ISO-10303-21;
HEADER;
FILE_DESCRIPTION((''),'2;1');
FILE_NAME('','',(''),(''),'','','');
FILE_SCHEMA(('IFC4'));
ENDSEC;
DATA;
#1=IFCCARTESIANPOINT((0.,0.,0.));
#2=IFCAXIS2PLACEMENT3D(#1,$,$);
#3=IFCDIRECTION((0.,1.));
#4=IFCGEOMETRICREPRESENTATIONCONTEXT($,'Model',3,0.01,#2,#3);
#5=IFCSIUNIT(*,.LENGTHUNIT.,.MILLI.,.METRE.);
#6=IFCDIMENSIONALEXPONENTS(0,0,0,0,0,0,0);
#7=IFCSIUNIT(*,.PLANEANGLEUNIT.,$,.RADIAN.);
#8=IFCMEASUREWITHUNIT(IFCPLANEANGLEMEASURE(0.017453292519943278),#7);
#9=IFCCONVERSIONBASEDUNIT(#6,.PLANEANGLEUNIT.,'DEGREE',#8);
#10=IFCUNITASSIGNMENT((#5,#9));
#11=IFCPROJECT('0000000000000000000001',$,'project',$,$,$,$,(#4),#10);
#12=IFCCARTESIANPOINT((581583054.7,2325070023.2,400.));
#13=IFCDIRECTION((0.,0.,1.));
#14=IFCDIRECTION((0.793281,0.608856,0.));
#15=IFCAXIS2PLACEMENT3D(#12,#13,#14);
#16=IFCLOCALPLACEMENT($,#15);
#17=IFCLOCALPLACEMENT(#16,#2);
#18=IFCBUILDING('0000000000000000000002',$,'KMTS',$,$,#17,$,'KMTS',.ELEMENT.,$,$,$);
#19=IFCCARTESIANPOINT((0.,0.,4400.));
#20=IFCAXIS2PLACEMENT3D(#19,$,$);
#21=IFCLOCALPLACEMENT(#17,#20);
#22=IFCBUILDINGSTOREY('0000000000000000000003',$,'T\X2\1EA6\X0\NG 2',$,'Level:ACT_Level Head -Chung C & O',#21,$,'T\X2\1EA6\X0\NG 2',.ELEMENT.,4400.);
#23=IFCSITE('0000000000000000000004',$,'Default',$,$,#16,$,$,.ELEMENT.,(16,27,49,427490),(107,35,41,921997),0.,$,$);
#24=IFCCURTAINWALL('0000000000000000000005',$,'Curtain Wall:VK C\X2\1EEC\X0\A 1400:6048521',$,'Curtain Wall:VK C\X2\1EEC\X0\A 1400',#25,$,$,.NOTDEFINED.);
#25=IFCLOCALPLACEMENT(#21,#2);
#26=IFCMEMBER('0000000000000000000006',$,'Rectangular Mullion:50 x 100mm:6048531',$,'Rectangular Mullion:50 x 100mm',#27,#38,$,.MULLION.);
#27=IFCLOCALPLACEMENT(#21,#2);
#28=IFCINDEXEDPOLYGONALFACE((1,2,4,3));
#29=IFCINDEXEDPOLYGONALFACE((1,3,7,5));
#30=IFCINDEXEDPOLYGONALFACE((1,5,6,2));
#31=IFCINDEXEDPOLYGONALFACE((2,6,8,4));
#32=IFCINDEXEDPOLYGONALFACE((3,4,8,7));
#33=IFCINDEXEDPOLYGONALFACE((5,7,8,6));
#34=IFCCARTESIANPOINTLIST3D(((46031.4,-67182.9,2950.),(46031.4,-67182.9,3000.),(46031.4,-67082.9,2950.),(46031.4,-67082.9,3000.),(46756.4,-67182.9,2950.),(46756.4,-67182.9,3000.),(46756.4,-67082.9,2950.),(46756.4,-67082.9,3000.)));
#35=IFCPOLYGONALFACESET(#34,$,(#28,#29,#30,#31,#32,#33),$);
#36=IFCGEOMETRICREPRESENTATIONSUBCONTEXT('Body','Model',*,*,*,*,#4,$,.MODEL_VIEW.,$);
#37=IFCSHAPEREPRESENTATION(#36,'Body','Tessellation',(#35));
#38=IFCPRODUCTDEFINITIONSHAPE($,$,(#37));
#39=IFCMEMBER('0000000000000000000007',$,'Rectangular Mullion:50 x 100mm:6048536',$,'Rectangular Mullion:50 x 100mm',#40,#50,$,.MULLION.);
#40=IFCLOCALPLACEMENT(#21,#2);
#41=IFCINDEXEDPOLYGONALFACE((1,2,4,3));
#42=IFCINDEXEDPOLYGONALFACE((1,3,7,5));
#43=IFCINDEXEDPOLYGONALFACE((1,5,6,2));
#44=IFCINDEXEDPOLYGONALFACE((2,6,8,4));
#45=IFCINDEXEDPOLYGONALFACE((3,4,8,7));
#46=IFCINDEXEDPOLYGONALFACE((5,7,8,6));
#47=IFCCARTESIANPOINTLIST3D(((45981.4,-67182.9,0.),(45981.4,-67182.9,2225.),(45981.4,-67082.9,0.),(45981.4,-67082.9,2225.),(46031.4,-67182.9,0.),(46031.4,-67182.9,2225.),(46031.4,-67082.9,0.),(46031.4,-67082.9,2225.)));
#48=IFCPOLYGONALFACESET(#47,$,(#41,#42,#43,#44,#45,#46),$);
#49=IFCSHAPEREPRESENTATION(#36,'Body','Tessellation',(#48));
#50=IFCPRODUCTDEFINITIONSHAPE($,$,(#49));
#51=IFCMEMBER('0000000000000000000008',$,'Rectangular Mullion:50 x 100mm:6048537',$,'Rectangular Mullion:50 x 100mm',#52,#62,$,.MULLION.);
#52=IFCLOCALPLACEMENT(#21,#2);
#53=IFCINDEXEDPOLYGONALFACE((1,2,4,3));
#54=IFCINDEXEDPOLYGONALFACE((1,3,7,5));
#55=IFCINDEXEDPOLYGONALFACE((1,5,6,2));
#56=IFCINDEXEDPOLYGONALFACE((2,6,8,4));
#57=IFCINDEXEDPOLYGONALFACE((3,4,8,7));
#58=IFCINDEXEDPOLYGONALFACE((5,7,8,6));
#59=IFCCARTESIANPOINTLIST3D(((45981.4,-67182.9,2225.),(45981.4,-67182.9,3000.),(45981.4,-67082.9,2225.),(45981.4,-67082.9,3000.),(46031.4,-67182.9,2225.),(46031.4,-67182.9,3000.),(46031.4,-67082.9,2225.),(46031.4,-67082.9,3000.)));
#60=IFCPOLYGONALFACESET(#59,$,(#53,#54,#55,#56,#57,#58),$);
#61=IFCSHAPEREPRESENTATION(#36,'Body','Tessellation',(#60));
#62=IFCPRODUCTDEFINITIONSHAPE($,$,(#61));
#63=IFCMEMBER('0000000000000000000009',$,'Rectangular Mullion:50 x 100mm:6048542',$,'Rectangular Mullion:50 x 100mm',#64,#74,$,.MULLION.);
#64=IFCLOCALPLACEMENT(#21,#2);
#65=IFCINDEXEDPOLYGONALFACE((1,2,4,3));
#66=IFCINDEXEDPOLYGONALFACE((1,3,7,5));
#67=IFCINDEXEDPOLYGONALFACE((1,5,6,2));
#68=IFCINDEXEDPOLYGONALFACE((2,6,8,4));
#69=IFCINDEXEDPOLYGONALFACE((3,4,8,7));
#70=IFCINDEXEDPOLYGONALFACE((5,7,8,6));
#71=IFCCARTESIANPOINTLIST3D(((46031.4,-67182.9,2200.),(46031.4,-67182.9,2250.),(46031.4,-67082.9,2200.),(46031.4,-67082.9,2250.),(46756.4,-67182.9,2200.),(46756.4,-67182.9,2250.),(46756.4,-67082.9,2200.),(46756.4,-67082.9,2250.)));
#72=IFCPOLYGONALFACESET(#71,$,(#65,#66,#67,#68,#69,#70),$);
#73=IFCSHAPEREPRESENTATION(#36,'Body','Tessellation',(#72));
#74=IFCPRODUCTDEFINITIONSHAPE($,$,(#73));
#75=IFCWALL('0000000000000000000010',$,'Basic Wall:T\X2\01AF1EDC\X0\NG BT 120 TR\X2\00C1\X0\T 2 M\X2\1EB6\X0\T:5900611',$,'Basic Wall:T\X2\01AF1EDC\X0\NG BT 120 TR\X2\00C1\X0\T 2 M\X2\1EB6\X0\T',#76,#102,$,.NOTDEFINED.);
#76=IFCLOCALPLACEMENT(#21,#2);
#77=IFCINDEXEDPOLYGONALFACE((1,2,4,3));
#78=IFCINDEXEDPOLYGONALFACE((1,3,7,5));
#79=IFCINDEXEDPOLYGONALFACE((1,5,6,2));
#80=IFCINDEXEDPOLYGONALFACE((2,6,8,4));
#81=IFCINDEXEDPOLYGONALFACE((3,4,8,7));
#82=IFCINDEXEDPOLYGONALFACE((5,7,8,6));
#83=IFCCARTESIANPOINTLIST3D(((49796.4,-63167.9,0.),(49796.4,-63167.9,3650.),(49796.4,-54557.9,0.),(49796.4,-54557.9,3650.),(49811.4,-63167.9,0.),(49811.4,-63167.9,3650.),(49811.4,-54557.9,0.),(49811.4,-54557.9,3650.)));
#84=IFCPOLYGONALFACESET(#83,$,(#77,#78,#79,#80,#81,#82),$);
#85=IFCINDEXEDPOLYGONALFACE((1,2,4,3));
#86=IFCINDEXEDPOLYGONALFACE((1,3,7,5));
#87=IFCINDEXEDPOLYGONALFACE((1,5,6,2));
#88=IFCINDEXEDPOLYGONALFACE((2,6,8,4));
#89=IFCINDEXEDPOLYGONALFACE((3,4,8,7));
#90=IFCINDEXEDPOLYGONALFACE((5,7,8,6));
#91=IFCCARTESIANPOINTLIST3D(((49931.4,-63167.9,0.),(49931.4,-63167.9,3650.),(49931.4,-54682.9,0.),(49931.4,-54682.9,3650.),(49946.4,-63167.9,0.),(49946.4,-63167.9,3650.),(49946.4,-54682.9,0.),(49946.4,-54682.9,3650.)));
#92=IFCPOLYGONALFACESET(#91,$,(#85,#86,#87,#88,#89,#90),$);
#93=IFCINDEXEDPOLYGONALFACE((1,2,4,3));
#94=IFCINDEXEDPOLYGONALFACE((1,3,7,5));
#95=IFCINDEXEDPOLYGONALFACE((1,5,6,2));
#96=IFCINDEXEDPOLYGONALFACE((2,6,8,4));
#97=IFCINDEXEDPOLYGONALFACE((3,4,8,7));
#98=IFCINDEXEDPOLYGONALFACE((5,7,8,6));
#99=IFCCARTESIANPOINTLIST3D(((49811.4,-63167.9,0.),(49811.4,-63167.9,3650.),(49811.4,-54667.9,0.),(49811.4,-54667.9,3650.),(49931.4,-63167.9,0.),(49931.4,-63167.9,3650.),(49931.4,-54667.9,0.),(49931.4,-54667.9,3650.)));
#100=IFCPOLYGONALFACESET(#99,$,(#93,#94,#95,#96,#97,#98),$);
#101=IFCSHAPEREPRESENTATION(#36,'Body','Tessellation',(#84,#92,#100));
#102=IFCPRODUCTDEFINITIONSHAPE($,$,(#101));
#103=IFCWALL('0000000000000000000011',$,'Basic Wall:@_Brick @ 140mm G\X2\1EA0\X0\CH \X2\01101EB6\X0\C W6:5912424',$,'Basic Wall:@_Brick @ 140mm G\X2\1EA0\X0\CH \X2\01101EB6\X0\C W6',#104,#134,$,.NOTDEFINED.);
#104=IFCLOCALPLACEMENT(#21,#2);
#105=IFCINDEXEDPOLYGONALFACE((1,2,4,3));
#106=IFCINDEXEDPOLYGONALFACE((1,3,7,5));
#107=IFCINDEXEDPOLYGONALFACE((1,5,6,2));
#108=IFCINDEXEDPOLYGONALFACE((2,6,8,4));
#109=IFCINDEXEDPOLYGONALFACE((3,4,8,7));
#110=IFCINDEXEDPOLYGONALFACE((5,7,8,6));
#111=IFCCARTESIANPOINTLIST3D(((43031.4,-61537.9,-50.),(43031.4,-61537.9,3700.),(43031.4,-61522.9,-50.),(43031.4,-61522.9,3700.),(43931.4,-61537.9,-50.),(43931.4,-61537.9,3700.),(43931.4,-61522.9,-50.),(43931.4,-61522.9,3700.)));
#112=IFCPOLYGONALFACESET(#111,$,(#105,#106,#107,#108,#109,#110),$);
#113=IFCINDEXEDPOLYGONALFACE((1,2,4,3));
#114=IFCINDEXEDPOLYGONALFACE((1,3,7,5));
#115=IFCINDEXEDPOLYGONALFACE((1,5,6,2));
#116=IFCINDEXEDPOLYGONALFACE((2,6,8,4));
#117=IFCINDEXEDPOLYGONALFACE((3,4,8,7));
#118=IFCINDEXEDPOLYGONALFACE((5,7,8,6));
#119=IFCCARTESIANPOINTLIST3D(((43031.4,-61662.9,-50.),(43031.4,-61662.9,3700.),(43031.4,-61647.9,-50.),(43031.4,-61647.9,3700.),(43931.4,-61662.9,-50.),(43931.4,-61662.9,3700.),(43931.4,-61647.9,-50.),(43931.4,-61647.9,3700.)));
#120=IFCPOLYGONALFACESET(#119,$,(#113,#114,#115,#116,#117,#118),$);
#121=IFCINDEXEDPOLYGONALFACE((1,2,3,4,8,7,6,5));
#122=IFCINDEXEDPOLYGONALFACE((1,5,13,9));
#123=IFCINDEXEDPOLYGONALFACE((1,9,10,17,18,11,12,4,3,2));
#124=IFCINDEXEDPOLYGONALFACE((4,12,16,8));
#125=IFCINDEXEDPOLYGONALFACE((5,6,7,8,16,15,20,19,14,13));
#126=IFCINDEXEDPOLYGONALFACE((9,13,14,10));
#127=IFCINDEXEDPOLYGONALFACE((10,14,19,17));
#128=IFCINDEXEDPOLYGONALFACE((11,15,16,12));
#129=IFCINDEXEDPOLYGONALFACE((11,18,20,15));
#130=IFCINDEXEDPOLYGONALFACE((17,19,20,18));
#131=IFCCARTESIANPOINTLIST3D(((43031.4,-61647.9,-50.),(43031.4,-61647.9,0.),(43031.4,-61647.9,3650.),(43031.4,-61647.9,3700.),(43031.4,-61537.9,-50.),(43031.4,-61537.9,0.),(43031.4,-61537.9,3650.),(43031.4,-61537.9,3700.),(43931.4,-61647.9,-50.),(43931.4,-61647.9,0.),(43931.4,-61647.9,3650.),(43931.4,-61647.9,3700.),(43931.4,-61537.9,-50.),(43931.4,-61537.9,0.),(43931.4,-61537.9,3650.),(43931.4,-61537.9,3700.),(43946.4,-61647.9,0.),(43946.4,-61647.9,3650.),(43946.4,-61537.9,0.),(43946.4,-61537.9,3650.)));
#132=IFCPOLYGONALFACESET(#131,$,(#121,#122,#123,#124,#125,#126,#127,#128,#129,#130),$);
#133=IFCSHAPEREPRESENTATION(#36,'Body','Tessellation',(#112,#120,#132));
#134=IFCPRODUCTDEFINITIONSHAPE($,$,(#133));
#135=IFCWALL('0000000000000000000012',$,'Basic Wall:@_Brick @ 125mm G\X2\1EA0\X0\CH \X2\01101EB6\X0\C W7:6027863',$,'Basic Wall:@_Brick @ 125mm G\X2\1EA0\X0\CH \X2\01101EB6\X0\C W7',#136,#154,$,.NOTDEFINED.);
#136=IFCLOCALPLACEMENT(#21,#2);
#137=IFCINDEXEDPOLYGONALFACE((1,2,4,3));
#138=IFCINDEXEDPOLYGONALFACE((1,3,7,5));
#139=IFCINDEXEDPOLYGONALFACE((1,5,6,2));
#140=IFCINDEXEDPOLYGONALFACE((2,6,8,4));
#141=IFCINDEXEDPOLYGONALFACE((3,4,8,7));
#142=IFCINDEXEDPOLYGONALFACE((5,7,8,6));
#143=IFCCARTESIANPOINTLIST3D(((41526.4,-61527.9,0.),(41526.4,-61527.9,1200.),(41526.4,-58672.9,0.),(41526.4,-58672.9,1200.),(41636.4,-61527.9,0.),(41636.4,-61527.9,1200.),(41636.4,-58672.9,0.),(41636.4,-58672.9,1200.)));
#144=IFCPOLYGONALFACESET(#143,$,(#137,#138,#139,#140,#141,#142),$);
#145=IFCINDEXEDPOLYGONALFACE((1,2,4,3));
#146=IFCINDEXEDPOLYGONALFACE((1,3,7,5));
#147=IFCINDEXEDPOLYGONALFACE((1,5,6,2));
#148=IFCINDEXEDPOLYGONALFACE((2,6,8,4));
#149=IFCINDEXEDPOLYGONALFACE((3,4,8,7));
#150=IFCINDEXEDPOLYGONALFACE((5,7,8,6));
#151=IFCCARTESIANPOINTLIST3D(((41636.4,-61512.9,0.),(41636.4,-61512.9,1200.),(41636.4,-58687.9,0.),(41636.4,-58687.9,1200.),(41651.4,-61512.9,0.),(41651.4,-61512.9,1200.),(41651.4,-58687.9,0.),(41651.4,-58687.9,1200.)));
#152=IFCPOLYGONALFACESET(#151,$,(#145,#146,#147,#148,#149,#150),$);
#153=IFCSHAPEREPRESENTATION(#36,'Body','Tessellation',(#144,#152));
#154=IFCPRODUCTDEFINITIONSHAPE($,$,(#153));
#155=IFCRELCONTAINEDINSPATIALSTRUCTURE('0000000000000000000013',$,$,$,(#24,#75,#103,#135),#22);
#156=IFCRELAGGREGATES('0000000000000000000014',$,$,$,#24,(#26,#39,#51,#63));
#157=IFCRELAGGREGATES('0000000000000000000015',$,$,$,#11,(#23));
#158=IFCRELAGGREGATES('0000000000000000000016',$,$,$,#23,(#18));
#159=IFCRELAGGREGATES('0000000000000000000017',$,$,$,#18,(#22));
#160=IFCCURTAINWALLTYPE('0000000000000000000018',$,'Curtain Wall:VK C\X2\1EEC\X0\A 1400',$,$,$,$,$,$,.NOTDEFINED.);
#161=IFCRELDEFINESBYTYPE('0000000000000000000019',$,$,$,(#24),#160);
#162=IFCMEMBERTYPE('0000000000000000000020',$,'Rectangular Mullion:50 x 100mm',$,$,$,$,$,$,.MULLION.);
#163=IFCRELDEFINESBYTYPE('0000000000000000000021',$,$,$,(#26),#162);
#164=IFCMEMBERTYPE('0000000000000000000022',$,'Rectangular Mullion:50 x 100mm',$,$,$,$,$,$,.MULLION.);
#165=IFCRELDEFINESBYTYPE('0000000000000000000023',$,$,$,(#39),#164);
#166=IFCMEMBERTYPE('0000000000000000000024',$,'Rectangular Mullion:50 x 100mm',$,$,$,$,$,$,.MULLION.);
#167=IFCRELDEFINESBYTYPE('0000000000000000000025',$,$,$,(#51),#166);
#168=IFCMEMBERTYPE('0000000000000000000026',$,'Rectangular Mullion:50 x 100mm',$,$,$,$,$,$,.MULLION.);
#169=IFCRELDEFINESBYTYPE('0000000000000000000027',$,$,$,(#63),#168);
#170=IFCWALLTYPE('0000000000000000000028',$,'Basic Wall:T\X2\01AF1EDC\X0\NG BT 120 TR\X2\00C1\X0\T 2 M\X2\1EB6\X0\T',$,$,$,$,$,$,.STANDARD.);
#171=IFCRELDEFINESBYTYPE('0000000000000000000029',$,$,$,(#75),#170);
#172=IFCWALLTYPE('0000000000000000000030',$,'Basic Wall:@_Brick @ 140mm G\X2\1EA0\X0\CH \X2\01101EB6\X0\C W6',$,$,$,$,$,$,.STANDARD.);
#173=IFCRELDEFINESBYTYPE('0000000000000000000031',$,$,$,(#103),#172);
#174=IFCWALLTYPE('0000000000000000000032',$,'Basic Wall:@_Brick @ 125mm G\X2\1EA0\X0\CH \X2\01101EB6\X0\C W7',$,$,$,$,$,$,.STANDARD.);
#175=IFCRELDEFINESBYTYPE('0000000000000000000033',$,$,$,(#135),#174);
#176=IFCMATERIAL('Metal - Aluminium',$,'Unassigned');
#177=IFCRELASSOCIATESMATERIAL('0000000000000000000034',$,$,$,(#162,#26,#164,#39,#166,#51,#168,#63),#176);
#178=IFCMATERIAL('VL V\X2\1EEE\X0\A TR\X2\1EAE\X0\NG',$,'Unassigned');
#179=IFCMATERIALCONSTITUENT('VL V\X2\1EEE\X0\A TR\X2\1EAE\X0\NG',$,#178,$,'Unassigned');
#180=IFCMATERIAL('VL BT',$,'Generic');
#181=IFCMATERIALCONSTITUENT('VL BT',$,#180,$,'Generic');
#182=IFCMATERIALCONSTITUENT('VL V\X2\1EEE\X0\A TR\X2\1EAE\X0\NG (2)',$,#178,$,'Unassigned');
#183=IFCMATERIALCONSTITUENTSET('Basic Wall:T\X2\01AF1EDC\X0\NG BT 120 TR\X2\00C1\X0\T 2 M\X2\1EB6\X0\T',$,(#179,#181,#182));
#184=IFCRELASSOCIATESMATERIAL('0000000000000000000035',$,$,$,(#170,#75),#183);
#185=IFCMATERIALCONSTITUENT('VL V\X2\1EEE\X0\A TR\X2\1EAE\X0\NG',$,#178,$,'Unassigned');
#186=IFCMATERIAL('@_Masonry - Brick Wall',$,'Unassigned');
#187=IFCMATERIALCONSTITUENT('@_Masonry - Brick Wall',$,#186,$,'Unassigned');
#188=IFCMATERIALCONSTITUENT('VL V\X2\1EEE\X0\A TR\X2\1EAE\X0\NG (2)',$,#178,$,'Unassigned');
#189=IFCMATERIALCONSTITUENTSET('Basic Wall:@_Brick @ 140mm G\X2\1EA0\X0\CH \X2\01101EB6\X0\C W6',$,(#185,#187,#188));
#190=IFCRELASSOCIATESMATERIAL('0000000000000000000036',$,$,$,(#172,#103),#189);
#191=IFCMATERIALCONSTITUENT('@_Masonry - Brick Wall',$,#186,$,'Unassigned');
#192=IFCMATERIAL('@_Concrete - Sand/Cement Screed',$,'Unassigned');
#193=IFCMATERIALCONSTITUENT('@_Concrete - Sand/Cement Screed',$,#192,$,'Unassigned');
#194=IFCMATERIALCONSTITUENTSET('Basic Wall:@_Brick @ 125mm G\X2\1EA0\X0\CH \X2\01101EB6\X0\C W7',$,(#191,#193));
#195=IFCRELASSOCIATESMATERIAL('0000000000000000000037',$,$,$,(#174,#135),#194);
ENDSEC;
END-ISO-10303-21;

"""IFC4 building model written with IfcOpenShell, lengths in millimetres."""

from ifc_helpers import new_model, entity, si_unit, converted_unit, direction, frame, origin, place, context, subcontext, project, spatial, indexed_curve, outline, extrude, source, transform, mapped, material, constituent, constituent_set, type_object, type_shapes, element, aggregate, save


model = new_model("IFC4")

# Units and contexts
model_context = context("Model", 3, precision=0.01, world=origin(), true_north=direction((0.0, 1.0)))
body_context = subcontext(model_context, "Body", "Model", "MODEL_VIEW")
ifc_project = project(units=[si_unit("LENGTHUNIT", "METRE", prefix="MILLI"), converted_unit("PLANEANGLEUNIT", "DEGREE", entity("IfcPlaneAngleMeasure", 0.017453292519943278), si_unit("PLANEANGLEUNIT", "RADIAN"), dimensions=[0, 0, 0, 0, 0, 0, 0])], contexts=[model_context])

# Site, building, storey
site_placement = place(None, frame((581583054.7, 2325070023.2, 400.0), z_axis=(0.0, 0.0, 1.0), x_axis=(0.793281, 0.608856, 0.0)))
site = spatial("IfcSite", under=ifc_project, at=site_placement, Name="Default", CompositionType="ELEMENT", RefLatitude=(16, 27, 49, 427490), RefLongitude=(107, 35, 41, 921997), RefElevation=0.0)
building_placement = place(site_placement, origin())
building = spatial("IfcBuilding", under=site, at=building_placement, Name="KMTS", LongName="KMTS", CompositionType="ELEMENT")
storey_placement = place(building_placement, frame((0.0, 0.0, 4400.0)))
storey = spatial("IfcBuildingStorey", under=building, at=storey_placement, Name="TẦNG 2", ObjectType="Level:ACT_Level Head -Chung C & O", LongName="TẦNG 2", CompositionType="ELEMENT", Elevation=4400.0)

# Curtain wall, members
curtain_wall_type = type_object("IfcCurtainWallType", Name="Curtain Wall:VK CỬA 1400", PredefinedType="NOTDEFINED")
curtain_wall_placement = place(storey_placement, frame((0.0, 0.0, -4400.0)))
curtain_wall = element("IfcCurtainWall", 1, at=curtain_wall_placement, inside=storey, type_object=curtain_wall_type, Name="Curtain Wall:VK CỬA 1400:6048521", ObjectType="Curtain Wall:VK CỬA 1400", PredefinedType="NOTDEFINED")
ifc_material_1 = material(Name="Metal - Aluminium", Category="Unassigned")
member_type_1 = type_object("IfcMemberType", Name="Rectangular Mullion:50 x 100mm", PredefinedType="MULLION", material=ifc_material_1)
shared_shape_1 = source(origin(), body_context, "Body", "SweptSolid", [
    extrude(outline(indexed_curve([(-25.0, -50.0), (25.0, -50.0), (25.0, 50.0), (-25.0, 50.0), (-25.0, -50.0)], self_intersect=False)), frame((-25.0, 0.0, -725.0), z_axis=(0.0, 0.0, 1.0), x_axis=(-1.0, 0.0, 0.0)), (0.0, 0.0, 1.0), 725.0),
])
type_shapes(member_type_1, [shared_shape_1])
member_1_placement = place(curtain_wall_placement, frame((46031.4, -67132.9, 7400.0), z_axis=(-1.0, 0.0, 0.0), x_axis=(0.0, 0.0, 1.0)))
member_1 = element("IfcMember", 2, at=member_1_placement, type_object=member_type_1, material=ifc_material_1, Name="Rectangular Mullion:50 x 100mm:6048531", ObjectType="Rectangular Mullion:50 x 100mm", PredefinedType="MULLION", context=body_context, shape_type="MappedRepresentation", body=[
    mapped(shared_shape_1, transform((0.0, 0.0, 0.0), scale=1.0)),
])
member_type_2 = type_object("IfcMemberType", Name="Rectangular Mullion:50 x 100mm", PredefinedType="MULLION", material=ifc_material_1)
shared_shape_2 = source(origin(), body_context, "Body", "SweptSolid", [
    extrude(outline(indexed_curve([(-25.0, -50.0), (25.0, -50.0), (25.0, 50.0), (-25.0, 50.0), (-25.0, -50.0)], self_intersect=False)), frame((-25.0, 0.0, -2225.0), z_axis=(0.0, 0.0, 1.0), x_axis=(-1.0, 0.0, 0.0)), (0.0, 0.0, 1.0), 2225.0),
])
type_shapes(member_type_2, [shared_shape_2])
member_2_placement = place(curtain_wall_placement, frame((45981.4, -67132.9, 4400.0), z_axis=(0.0, 0.0, -1.0), x_axis=(-1.0, 0.0, 0.0)))
member_2 = element("IfcMember", 3, at=member_2_placement, type_object=member_type_2, material=ifc_material_1, Name="Rectangular Mullion:50 x 100mm:6048536", ObjectType="Rectangular Mullion:50 x 100mm", PredefinedType="MULLION", context=body_context, shape_type="MappedRepresentation", body=[
    mapped(shared_shape_2, transform((0.0, 0.0, 0.0), scale=1.0)),
])
member_type_3 = type_object("IfcMemberType", Name="Rectangular Mullion:50 x 100mm", PredefinedType="MULLION", material=ifc_material_1)
shared_shape_3 = source(origin(), body_context, "Body", "SweptSolid", [
    extrude(outline(indexed_curve([(-25.0, -50.0), (25.0, -50.0), (25.0, 50.0), (-25.0, 50.0), (-25.0, -50.0)], self_intersect=False)), frame((-25.0, 0.0, -775.0), z_axis=(0.0, 0.0, 1.0), x_axis=(-1.0, 0.0, 0.0)), (0.0, 0.0, 1.0), 775.0),
])
type_shapes(member_type_3, [shared_shape_3])
member_3_placement = place(curtain_wall_placement, frame((45981.4, -67132.9, 6625.0), z_axis=(0.0, 0.0, -1.0), x_axis=(-1.0, 0.0, 0.0)))
member_3 = element("IfcMember", 4, at=member_3_placement, type_object=member_type_3, material=ifc_material_1, Name="Rectangular Mullion:50 x 100mm:6048537", ObjectType="Rectangular Mullion:50 x 100mm", PredefinedType="MULLION", context=body_context, shape_type="MappedRepresentation", body=[
    mapped(shared_shape_3, transform((0.0, 0.0, 0.0), scale=1.0)),
])
member_type_4 = type_object("IfcMemberType", Name="Rectangular Mullion:50 x 100mm", PredefinedType="MULLION", material=ifc_material_1)
shared_shape_4 = source(origin(), body_context, "Body", "SweptSolid", [
    extrude(outline(indexed_curve([(-25.0, -50.0), (25.0, -50.0), (25.0, 50.0), (-25.0, 50.0), (-25.0, -50.0)], self_intersect=False)), frame((0.0, 0.0, -725.0), z_axis=(0.0, 0.0, 1.0), x_axis=(-1.0, 0.0, 0.0)), (0.0, 0.0, 1.0), 725.0),
])
type_shapes(member_type_4, [shared_shape_4])
member_4_placement = place(curtain_wall_placement, frame((46031.4, -67132.9, 6625.0), z_axis=(-1.0, 0.0, 0.0), x_axis=(0.0, 0.0, 1.0)))
member_4 = element("IfcMember", 5, at=member_4_placement, type_object=member_type_4, material=ifc_material_1, Name="Rectangular Mullion:50 x 100mm:6048542", ObjectType="Rectangular Mullion:50 x 100mm", PredefinedType="MULLION", context=body_context, shape_type="MappedRepresentation", body=[
    mapped(shared_shape_4, transform((0.0, 0.0, 0.0), scale=1.0)),
])
aggregate(curtain_wall, [member_1, member_2, member_3, member_4])

# Shared definitions
ifc_material_2 = material(Name="VL VỮA TRẮNG", Category="Unassigned")
ifc_material_3 = material(Name="VL BT", Category="Generic")

# Shared definitions
ifc_constituent_1 = constituent(ifc_material_2, Name="VL VỮA TRẮNG", Category="Unassigned")
ifc_constituent_2 = constituent(ifc_material_3, Name="VL BT", Category="Generic")
ifc_constituent_3 = constituent(ifc_material_2, Name="VL VỮA TRẮNG (2)", Category="Unassigned")
ifc_constituent_set_1 = constituent_set(constituents=[ifc_constituent_1, ifc_constituent_2, ifc_constituent_3], Name="Basic Wall:TƯỜNG BT 120 TRÁT 2 MẶT")
wall_type_1 = type_object("IfcWallType", Name="Basic Wall:TƯỜNG BT 120 TRÁT 2 MẶT", PredefinedType="STANDARD", material=ifc_constituent_set_1)

# Wall
wall_1_placement = place(storey_placement, frame((49871.4, -54682.9, 0.0), z_axis=(0.0, 0.0, 1.0), x_axis=(0.0, -1.0, 0.0)))
element("IfcWall", 6, at=wall_1_placement, inside=storey, type_object=wall_type_1, material=ifc_constituent_set_1, Name="Basic Wall:TƯỜNG BT 120 TRÁT 2 MẶT:5900611", ObjectType="Basic Wall:TƯỜNG BT 120 TRÁT 2 MẶT", PredefinedType="NOTDEFINED", context=body_context, shape_type="SweptSolid", body=[
    extrude(outline(indexed_curve([(-7.5, -4305.0), (7.5, -4305.0), (7.5, 4305.0), (-7.5, 4305.0), (-7.5, -4305.0)], self_intersect=False)), frame((4180.0, -67.5, 0.0), z_axis=(0.0, 0.0, 1.0), x_axis=(0.0, 1.0, 0.0)), (0.0, 0.0, 1.0), 3650.0),
    extrude(outline(indexed_curve([(-7.5, -4242.5), (7.5, -4242.5), (7.5, 4242.5), (-7.5, 4242.5), (-7.5, -4242.5)], self_intersect=False)), frame((4242.5, 67.5, 0.0), z_axis=(0.0, 0.0, 1.0), x_axis=(0.0, -1.0, 0.0)), (0.0, 0.0, 1.0), 3650.0),
    extrude(outline(indexed_curve([(-4250.0, -60.0), (4250.0, -60.0), (4250.0, 60.0), (-4250.0, 60.0), (-4250.0, -60.0)], self_intersect=False)), frame((4235.0, 0.0, 0.0)), (0.0, 0.0, 1.0), 3650.0),
])

# Walls
ifc_constituent_4 = constituent(ifc_material_2, Name="VL VỮA TRẮNG", Category="Unassigned")
ifc_material_4 = material(Name="@_Masonry - Brick Wall", Category="Unassigned")
ifc_constituent_5 = constituent(ifc_material_4, Name="@_Masonry - Brick Wall", Category="Unassigned")
ifc_constituent_6 = constituent(ifc_material_2, Name="VL VỮA TRẮNG (2)", Category="Unassigned")
ifc_constituent_set_2 = constituent_set(constituents=[ifc_constituent_4, ifc_constituent_5, ifc_constituent_6], Name="Basic Wall:@_Brick @ 140mm GẠCH ĐẶC W6")
wall_type_2 = type_object("IfcWallType", Name="Basic Wall:@_Brick @ 140mm GẠCH ĐẶC W6", PredefinedType="STANDARD", material=ifc_constituent_set_2)
wall_2_placement = place(storey_placement, frame((43931.4, -61592.9, -50.0), z_axis=(0.0, 0.0, 1.0), x_axis=(-1.0, 0.0, 0.0)))
element("IfcWall", 7, at=wall_2_placement, inside=storey, type_object=wall_type_2, material=ifc_constituent_set_2, Name="Basic Wall:@_Brick @ 140mm GẠCH ĐẶC W6:5912424", ObjectType="Basic Wall:@_Brick @ 140mm GẠCH ĐẶC W6", PredefinedType="NOTDEFINED", context=body_context, shape_type="SweptSolid", body=[
    extrude(outline(indexed_curve([(-7.5, -450.0), (7.5, -450.0), (7.5, 450.0), (-7.5, 450.0), (-7.5, -450.0)], self_intersect=False)), frame((450.0, -62.5, 0.0), z_axis=(0.0, 0.0, 1.0), x_axis=(0.0, 1.0, 0.0)), (0.0, 0.0, 1.0), 3750.0),
    extrude(outline(indexed_curve([(-7.5, -450.0), (7.5, -450.0), (7.5, 450.0), (-7.5, 450.0), (-7.5, -450.0)], self_intersect=False)), frame((450.0, 62.5, 0.0), z_axis=(0.0, 0.0, 1.0), x_axis=(0.0, -1.0, 0.0)), (0.0, 0.0, 1.0), 3750.0),
    extrude(outline(indexed_curve([(-1875.0, -543.0), (-1825.0, -543.0), (1825.0, -543.0), (1875.0, -543.0), (1875.0, 357.0), (1825.0, 357.0), (1825.0, 372.0), (-1825.0, 372.0), (-1825.0, 357.0), (-1875.0, 357.0), (-1875.0, -543.0)], self_intersect=False)), frame((357.0, 55.0, 1875.0), z_axis=(0.0, -1.0, 0.0), x_axis=(0.0, 0.0, 1.0)), (0.0, 0.0, 1.0), 110.0),
])
ifc_constituent_7 = constituent(ifc_material_4, Name="@_Masonry - Brick Wall", Category="Unassigned")
ifc_material_5 = material(Name="@_Concrete - Sand/Cement Screed", Category="Unassigned")
ifc_constituent_8 = constituent(ifc_material_5, Name="@_Concrete - Sand/Cement Screed", Category="Unassigned")
ifc_constituent_set_3 = constituent_set(constituents=[ifc_constituent_7, ifc_constituent_8], Name="Basic Wall:@_Brick @ 125mm GẠCH ĐẶC W7")
wall_type_3 = type_object("IfcWallType", Name="Basic Wall:@_Brick @ 125mm GẠCH ĐẶC W7", PredefinedType="STANDARD", material=ifc_constituent_set_3)
wall_3_placement = place(storey_placement, frame((41588.9, -61512.9, 0.0), z_axis=(0.0, 0.0, 1.0), x_axis=(0.0, 1.0, 0.0)))
element("IfcWall", 8, at=wall_3_placement, inside=storey, type_object=wall_type_3, material=ifc_constituent_set_3, Name="Basic Wall:@_Brick @ 125mm GẠCH ĐẶC W7:6027863", ObjectType="Basic Wall:@_Brick @ 125mm GẠCH ĐẶC W7", PredefinedType="NOTDEFINED", context=body_context, shape_type="SweptSolid", body=[
    extrude(outline(indexed_curve([(-55.0, -1427.5), (55.0, -1427.5), (55.0, 1427.5), (-55.0, 1427.5), (-55.0, -1427.5)], self_intersect=False)), frame((1412.5, 7.5, 0.0), z_axis=(0.0, 0.0, 1.0), x_axis=(0.0, -1.0, 0.0)), (0.0, 0.0, 1.0), 1200.0),
    extrude(outline(indexed_curve([(-7.5, -1412.5), (7.5, -1412.5), (7.5, 1412.5), (-7.5, 1412.5), (-7.5, -1412.5)], self_intersect=False)), frame((1412.5, -55.0, 0.0), z_axis=(0.0, 0.0, 1.0), x_axis=(0.0, 1.0, 0.0)), (0.0, 0.0, 1.0), 1200.0),
])

save(model, "model.ifc")
